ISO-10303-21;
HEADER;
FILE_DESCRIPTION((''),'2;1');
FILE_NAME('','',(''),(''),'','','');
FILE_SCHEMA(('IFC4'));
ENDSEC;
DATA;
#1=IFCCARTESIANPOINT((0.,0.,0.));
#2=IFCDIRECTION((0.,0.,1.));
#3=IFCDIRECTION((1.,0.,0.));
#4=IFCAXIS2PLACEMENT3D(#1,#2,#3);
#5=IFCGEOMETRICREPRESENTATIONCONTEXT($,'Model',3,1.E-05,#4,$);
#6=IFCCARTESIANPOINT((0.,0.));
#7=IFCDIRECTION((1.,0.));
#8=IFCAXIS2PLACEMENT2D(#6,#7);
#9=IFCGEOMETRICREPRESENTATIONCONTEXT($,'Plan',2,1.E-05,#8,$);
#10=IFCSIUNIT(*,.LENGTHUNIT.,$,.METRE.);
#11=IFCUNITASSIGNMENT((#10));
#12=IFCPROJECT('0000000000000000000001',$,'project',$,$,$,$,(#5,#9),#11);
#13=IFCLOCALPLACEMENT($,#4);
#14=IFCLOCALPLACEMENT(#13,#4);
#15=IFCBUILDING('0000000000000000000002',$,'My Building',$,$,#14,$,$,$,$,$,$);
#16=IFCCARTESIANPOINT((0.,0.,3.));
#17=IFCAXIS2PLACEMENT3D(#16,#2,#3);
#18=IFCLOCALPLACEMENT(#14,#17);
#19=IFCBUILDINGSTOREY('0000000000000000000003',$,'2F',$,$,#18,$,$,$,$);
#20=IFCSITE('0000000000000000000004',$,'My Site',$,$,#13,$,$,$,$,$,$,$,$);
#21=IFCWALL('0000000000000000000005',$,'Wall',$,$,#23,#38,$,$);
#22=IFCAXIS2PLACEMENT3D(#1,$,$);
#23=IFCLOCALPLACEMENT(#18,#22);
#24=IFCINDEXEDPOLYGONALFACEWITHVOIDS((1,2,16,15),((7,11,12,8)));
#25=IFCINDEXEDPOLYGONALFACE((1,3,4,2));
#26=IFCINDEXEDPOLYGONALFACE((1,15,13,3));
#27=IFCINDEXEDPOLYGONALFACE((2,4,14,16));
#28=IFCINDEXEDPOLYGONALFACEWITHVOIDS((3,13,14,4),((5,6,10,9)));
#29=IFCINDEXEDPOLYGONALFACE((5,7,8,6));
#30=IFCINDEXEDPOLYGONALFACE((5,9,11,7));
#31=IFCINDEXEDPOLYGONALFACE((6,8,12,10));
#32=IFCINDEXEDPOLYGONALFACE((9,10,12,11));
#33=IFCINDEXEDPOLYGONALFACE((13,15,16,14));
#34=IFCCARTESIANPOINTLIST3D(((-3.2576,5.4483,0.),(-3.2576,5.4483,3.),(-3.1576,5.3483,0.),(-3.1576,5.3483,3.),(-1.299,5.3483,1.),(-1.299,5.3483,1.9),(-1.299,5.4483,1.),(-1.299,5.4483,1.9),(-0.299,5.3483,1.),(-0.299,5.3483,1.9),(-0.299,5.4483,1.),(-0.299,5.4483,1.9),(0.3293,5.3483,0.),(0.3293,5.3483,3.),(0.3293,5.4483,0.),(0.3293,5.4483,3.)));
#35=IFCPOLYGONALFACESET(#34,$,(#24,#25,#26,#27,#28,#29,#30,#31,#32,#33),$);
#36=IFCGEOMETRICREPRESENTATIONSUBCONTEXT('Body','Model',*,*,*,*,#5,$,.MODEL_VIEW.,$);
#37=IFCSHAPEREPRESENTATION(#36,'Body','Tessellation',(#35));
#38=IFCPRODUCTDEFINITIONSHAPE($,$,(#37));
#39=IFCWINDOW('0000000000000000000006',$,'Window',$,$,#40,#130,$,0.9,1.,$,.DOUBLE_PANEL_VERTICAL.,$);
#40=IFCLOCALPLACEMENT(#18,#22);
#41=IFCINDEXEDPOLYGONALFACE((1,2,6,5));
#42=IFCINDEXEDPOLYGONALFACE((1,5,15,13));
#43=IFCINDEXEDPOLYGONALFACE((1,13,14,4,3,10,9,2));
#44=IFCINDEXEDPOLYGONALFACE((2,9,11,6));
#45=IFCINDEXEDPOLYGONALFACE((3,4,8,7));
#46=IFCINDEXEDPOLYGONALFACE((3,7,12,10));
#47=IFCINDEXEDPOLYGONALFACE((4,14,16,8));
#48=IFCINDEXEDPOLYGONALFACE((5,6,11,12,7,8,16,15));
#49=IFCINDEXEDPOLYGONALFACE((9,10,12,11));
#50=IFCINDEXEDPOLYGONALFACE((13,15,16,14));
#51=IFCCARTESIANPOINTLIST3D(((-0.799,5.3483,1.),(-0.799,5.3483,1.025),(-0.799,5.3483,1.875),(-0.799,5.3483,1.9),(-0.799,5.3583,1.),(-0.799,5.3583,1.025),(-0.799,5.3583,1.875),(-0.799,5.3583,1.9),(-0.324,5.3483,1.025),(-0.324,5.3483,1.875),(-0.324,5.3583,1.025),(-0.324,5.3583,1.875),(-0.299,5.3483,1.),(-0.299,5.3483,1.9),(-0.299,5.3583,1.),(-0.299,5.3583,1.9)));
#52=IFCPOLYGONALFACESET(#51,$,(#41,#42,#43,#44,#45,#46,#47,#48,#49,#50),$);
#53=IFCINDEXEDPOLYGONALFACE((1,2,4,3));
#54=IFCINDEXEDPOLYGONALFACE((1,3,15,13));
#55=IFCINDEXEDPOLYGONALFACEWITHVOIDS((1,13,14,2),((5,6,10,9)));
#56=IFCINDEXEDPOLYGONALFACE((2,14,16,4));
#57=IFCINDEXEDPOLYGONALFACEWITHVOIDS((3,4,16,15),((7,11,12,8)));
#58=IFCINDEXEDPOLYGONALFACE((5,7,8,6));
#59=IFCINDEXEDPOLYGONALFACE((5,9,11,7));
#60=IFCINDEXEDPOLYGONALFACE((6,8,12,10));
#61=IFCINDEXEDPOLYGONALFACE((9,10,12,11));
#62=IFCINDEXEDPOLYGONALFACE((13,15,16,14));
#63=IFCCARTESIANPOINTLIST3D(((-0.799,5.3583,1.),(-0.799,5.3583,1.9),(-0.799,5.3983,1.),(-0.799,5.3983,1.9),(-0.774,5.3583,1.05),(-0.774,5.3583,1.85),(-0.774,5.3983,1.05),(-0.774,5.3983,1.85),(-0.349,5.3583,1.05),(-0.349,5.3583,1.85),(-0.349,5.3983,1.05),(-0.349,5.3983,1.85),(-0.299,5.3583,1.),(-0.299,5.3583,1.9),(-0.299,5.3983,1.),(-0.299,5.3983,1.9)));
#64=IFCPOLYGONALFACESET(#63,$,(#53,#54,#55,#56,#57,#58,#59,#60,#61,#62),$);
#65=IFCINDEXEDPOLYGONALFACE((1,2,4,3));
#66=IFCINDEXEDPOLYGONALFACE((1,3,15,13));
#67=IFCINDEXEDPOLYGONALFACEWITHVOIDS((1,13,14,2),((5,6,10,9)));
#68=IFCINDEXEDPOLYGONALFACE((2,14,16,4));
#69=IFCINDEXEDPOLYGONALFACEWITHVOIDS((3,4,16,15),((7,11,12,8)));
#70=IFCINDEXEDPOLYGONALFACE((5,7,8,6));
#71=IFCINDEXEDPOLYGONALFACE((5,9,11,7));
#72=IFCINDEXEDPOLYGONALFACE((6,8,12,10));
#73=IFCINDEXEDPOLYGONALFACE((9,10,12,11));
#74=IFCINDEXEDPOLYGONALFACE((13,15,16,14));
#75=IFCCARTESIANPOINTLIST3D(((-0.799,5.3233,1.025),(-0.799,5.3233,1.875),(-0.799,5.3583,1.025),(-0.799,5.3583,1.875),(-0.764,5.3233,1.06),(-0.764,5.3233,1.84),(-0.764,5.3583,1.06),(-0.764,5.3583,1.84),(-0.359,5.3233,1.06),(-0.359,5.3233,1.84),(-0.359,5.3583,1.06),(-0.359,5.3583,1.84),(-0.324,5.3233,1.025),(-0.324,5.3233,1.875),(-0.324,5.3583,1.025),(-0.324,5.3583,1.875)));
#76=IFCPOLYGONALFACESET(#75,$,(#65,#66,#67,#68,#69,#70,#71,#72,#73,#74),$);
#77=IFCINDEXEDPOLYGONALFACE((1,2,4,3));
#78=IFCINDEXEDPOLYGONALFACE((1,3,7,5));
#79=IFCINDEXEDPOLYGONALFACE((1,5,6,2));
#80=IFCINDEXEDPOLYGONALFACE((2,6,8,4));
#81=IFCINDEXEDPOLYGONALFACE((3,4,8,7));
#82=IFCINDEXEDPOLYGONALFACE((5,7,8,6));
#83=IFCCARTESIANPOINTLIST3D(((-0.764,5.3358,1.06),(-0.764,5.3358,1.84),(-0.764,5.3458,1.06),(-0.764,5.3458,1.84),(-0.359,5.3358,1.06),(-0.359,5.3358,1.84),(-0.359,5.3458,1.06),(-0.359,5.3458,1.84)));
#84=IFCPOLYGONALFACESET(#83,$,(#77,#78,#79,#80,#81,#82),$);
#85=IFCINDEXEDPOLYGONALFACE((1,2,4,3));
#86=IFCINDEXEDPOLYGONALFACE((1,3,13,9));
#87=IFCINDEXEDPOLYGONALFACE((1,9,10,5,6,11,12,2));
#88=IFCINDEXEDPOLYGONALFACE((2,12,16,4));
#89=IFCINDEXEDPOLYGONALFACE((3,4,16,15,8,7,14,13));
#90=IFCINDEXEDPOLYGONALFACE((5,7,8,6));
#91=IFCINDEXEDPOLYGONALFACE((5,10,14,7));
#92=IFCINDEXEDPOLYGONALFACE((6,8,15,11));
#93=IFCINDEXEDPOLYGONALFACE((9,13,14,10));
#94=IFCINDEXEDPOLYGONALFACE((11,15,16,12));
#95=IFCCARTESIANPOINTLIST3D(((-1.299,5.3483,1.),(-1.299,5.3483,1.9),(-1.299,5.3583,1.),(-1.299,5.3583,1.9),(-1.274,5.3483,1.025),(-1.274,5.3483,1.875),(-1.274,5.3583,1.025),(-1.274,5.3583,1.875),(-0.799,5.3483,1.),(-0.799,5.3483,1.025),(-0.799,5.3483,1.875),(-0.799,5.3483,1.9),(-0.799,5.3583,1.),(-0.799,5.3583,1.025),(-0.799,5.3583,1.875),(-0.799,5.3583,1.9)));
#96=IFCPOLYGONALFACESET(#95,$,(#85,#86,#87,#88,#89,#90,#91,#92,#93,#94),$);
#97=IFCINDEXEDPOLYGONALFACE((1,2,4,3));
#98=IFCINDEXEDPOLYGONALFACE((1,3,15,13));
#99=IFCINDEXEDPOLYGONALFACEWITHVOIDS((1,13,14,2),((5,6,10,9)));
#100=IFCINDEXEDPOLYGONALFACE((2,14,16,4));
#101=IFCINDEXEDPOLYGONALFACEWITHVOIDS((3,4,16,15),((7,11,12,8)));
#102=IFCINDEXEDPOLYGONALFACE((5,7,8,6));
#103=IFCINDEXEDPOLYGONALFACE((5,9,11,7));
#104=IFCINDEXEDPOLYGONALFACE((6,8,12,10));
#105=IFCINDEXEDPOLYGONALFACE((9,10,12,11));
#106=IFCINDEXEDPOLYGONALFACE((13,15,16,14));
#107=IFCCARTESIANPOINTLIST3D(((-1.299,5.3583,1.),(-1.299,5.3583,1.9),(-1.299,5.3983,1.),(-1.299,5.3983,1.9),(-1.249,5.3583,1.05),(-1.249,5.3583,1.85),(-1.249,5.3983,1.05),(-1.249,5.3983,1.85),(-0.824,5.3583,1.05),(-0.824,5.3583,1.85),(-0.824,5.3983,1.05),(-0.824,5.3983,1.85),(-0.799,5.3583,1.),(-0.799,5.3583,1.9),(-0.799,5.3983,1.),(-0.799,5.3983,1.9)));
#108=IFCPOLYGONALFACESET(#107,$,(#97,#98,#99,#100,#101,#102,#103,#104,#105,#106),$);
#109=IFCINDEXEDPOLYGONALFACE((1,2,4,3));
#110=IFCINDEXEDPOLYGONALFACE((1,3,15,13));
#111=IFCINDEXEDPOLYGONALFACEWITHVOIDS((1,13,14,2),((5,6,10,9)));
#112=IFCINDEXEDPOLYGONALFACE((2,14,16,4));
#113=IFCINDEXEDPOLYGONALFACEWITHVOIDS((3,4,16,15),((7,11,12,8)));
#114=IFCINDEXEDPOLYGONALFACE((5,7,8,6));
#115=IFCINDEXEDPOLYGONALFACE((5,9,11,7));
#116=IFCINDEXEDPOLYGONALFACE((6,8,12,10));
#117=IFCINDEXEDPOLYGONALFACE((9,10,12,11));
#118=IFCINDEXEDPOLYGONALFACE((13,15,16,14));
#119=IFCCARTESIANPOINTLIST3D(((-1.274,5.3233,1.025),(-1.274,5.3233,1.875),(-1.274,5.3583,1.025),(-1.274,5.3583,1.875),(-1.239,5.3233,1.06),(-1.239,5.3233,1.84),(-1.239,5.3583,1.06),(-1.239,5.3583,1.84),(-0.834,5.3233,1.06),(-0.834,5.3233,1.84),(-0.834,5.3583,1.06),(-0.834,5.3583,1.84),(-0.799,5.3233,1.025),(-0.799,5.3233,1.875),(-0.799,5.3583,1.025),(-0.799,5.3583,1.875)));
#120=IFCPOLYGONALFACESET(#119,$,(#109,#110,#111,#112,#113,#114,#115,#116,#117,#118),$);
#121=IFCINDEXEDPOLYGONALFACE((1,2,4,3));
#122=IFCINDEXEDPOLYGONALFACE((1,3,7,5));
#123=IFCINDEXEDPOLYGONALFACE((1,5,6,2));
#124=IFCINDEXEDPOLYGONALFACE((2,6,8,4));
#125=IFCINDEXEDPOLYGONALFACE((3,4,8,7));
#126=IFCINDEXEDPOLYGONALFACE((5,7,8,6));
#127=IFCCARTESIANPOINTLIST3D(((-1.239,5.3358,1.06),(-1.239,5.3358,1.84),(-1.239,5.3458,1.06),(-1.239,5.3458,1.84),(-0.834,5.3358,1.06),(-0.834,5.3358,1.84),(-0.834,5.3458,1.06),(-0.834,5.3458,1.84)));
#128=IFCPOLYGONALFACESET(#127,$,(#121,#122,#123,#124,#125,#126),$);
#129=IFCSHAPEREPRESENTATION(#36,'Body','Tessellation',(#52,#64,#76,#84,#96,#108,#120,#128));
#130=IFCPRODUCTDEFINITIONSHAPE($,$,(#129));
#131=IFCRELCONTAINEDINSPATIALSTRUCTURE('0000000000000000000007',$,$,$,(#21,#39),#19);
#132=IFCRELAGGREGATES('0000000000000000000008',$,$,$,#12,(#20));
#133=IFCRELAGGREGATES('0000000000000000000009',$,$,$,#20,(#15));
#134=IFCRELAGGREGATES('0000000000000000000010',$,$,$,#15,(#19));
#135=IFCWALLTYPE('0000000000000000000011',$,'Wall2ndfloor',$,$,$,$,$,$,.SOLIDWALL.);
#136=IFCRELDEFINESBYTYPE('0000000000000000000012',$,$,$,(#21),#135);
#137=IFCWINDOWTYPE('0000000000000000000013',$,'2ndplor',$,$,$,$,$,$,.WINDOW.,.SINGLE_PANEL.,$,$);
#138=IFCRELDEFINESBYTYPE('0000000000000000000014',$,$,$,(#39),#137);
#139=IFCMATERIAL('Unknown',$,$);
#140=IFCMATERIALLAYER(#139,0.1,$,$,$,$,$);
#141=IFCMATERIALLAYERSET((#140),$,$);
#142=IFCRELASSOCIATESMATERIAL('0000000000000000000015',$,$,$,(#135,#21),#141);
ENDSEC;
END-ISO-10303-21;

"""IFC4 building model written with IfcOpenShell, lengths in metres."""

from ifc_helpers import new_model, entity, si_unit, frame, origin_with_axes, origin_2d_with_axis, place, context, subcontext, project, spatial, line, indexed_curve, outline, extrude, shape, source, transform, mapped, material, layer, layer_set, layer_usage, type_object, type_shapes, element, fill, save


model = new_model("IFC4")

# Units and contexts
model_context = context("Model", 3, precision=1e-05, world=origin_with_axes())
plan_context = context("Plan", 2, precision=1e-05, world=origin_2d_with_axis())
body_context_1 = subcontext(model_context, "Body", "Model", "MODEL_VIEW")
body_context_2 = subcontext(plan_context, "Body", "Plan", "PLAN_VIEW")
ifc_project = project(units=[si_unit("LENGTHUNIT", "METRE")], contexts=[model_context, plan_context])

# Site, building, storey
site_placement = place(None, origin_with_axes())
site = spatial("IfcSite", under=ifc_project, at=site_placement, Name="My Site")
building_placement = place(site_placement, origin_with_axes())
building = spatial("IfcBuilding", under=site, at=building_placement, Name="My Building")
storey_placement = place(building_placement, frame((0.0, 0.0, 3.0), z_axis=(0.0, 0.0, 1.0), x_axis=(1.0, 0.0, 0.0)))
storey = spatial("IfcBuildingStorey", under=building, at=storey_placement, Name="2F")

# Shared definitions
ifc_material = material(Name="Unknown")

# Shared definitions
ifc_layer_1 = layer(ifc_material, 0.1)
ifc_layer_set_1 = layer_set([ifc_layer_1])
wall_type = type_object("IfcWallType", Name="Wall2ndfloor", PredefinedType="SOLIDWALL", material=ifc_layer_set_1)

# Wall, opening, window
ifc_layer_usage_1 = layer_usage(ifc_layer_set_1, "AXIS2", "POSITIVE", 0.0)
wall_1_placement = place(storey_placement, frame((0.4293, 5.4483, 0.0), z_axis=(0.0, 0.0, 1.0), x_axis=(-1.0, 0.0, 0.0)))
wall_1 = element("IfcWall", 1, at=wall_1_placement, inside=storey, type_object=wall_type, material=ifc_layer_usage_1, Name="Wall", context=body_context_1, shape_type="SweptSolid", body=[
    extrude(outline(indexed_curve([(0.1, 0.0), (0.1, 0.1), (3.5869, 0.1), (3.6869, 0.0)], segments=[line(1, 2, 3, 4, 1)])), origin_with_axes(), (0.0, 0.0, 1.0), 3.0),
])
shared_shape_1 = source(origin_with_axes(), body_context_1, "Body", "SweptSolid", [
    extrude(outline(indexed_curve([(0.0, 0.0), (1.0, 0.0), (1.0, 0.9), (0.0, 0.9)], segments=[line(1, 2, 3, 4, 1)])), frame((0.0, -0.6, 0.0), z_axis=(0.0, -1.0, 0.0), x_axis=(1.0, 0.0, 0.0)), (0.0, 0.0, -1.0), 1.2),
])
opening_1_placement = place(wall_1_placement, frame((0.7283, 0.0, 1.0), z_axis=(0.0, 0.0, 1.0), x_axis=(1.0, 0.0, 0.0)))
opening_1 = element("IfcOpeningElement", 2, at=opening_1_placement, cuts=wall_1, PredefinedType="OPENING", context=body_context_1, shape_type="MappedRepresentation", body=[
    mapped(shared_shape_1, transform((0.0, 0.0, 0.0), x_axis=(1.0, 0.0, 0.0), y_axis=(0.0, 1.0, 0.0), z_axis=(0.0, 0.0, 1.0), scale=1.0)),
])
window_type_1 = type_object("IfcWindowType", Name="2ndplor", PartitioningType="SINGLE_PANEL", PredefinedType="WINDOW")
shared_shape_2 = source(origin_with_axes(), body_context_1, "Body", "SweptSolid", [
    extrude(outline(indexed_curve([(0.5, 0.0), (0.0, 0.0), (0.0, 0.9), (0.5, 0.9), (0.5, 0.875), (0.025, 0.875), (0.025, 0.025), (0.5, 0.025)], segments=[line(1, 2, 3, 4, 5, 6, 7, 8, 1)])), frame((0.0, 0.09, 0.0), z_axis=(0.0, -1.0, 0.0), x_axis=(1.0, 0.0, 0.0)), (0.0, 0.0, -1.0), 0.01),
    extrude(outline(indexed_curve([(0.0, 0.0), (0.5, 0.0), (0.5, 0.9), (0.0, 0.9)], segments=[line(1, 2, 3, 4, 1)]), holes=[indexed_curve([(0.05, 0.05), (0.475, 0.05), (0.475, 0.85), (0.05, 0.85)], segments=[line(1, 2, 3, 4, 1)])]), frame((0.0, 0.05, 0.0), z_axis=(0.0, -1.0, 0.0), x_axis=(1.0, 0.0, 0.0)), (0.0, 0.0, -1.0), 0.04),
    extrude(outline(indexed_curve([(0.0, 0.0), (0.475, 0.0), (0.475, 0.85), (0.0, 0.85)], segments=[line(1, 2, 3, 4, 1)]), holes=[indexed_curve([(0.035, 0.035), (0.44, 0.035), (0.44, 0.815), (0.035, 0.815)], segments=[line(1, 2, 3, 4, 1)])]), frame((0.025, 0.09, 0.025), z_axis=(0.0, -1.0, 0.0), x_axis=(1.0, 0.0, 0.0)), (0.0, 0.0, -1.0), 0.035),
    extrude(outline(indexed_curve([(0.035, 0.035), (0.44, 0.035), (0.44, 0.815), (0.035, 0.815)], segments=[line(1, 2, 3, 4, 1)])), frame((0.025, 0.1025, 0.025), z_axis=(0.0, -1.0, 0.0), x_axis=(1.0, 0.0, 0.0)), (0.0, 0.0, -1.0), 0.01),
    extrude(outline(indexed_curve([(0.0, 0.9), (0.5, 0.9), (0.5, 0.0), (0.0, 0.0), (0.0, 0.025), (0.475, 0.025), (0.475, 0.875), (0.0, 0.875)], segments=[line(1, 2, 3, 4, 5, 6, 7, 8, 1)])), frame((0.5, 0.09, 0.0), z_axis=(0.0, -1.0, 0.0), x_axis=(1.0, 0.0, 0.0)), (0.0, 0.0, -1.0), 0.01),
    extrude(outline(indexed_curve([(0.0, 0.0), (0.5, 0.0), (0.5, 0.9), (0.0, 0.9)], segments=[line(1, 2, 3, 4, 1)]), holes=[indexed_curve([(0.025, 0.05), (0.45, 0.05), (0.45, 0.85), (0.025, 0.85)], segments=[line(1, 2, 3, 4, 1)])]), frame((0.5, 0.05, 0.0), z_axis=(0.0, -1.0, 0.0), x_axis=(1.0, 0.0, 0.0)), (0.0, 0.0, -1.0), 0.04),
    extrude(outline(indexed_curve([(0.0, 0.0), (0.475, 0.0), (0.475, 0.85), (0.0, 0.85)], segments=[line(1, 2, 3, 4, 1)]), holes=[indexed_curve([(0.035, 0.035), (0.44, 0.035), (0.44, 0.815), (0.035, 0.815)], segments=[line(1, 2, 3, 4, 1)])]), frame((0.5, 0.09, 0.025), z_axis=(0.0, -1.0, 0.0), x_axis=(1.0, 0.0, 0.0)), (0.0, 0.0, -1.0), 0.035),
    extrude(outline(indexed_curve([(0.035, 0.035), (0.44, 0.035), (0.44, 0.815), (0.035, 0.815)], segments=[line(1, 2, 3, 4, 1)])), frame((0.5, 0.1025, 0.025), z_axis=(0.0, -1.0, 0.0), x_axis=(1.0, 0.0, 0.0)), (0.0, 0.0, -1.0), 0.01),
])
shared_shape_3 = source(origin_with_axes(), body_context_2, "Body", "Curve2D", [
    entity("IfcIndexedPolyCurve", entity("IfcCartesianPointList2D", [[0.05, 0.05], [0.475, 0.05]])),
    entity("IfcIndexedPolyCurve", entity("IfcCartesianPointList2D", [[0.0, 0.1], [0.025, 0.1], [0.025, 0.09], [0.05, 0.09], [0.05, 0.05], [0.0, 0.05]]), [entity("IfcLineIndex", [1, 2, 3, 4, 5, 6, 1])]),
    entity("IfcIndexedPolyCurve", entity("IfcCartesianPointList2D", [[0.5, 0.1], [0.5, 0.1], [0.5, 0.09], [0.475, 0.09], [0.475, 0.05], [0.5, 0.05]])),
    entity("IfcIndexedPolyCurve", entity("IfcCartesianPointList2D", [[0.025, 0.09], [0.06, 0.09], [0.06, 0.125], [0.025, 0.125]]), [entity("IfcLineIndex", [1, 2, 3, 4, 1])]),
    entity("IfcIndexedPolyCurve", entity("IfcCartesianPointList2D", [[0.5, 0.09], [0.465, 0.09], [0.465, 0.125], [0.5, 0.125]]), [entity("IfcLineIndex", [1, 2, 3, 4, 1])]),
    entity("IfcIndexedPolyCurve", entity("IfcCartesianPointList2D", [[0.06, 0.09], [0.465, 0.09]])),
    entity("IfcIndexedPolyCurve", entity("IfcCartesianPointList2D", [[0.06, 0.125], [0.465, 0.125]])),
    entity("IfcIndexedPolyCurve", entity("IfcCartesianPointList2D", [[0.06, 0.1075], [0.465, 0.1075]])),
    entity("IfcIndexedPolyCurve", entity("IfcCartesianPointList2D", [[0.525, 0.05], [0.95, 0.05]])),
    entity("IfcIndexedPolyCurve", entity("IfcCartesianPointList2D", [[0.5, 0.1], [0.5, 0.1], [0.5, 0.09], [0.525, 0.09], [0.525, 0.05], [0.5, 0.05]])),
    entity("IfcIndexedPolyCurve", entity("IfcCartesianPointList2D", [[1.0, 0.1], [0.975, 0.1], [0.975, 0.09], [0.95, 0.09], [0.95, 0.05], [1.0, 0.05]]), [entity("IfcLineIndex", [1, 2, 3, 4, 5, 6, 1])]),
    entity("IfcIndexedPolyCurve", entity("IfcCartesianPointList2D", [[0.5, 0.09], [0.535, 0.09], [0.535, 0.125], [0.5, 0.125]]), [entity("IfcLineIndex", [1, 2, 3, 4, 1])]),
    entity("IfcIndexedPolyCurve", entity("IfcCartesianPointList2D", [[0.975, 0.09], [0.94, 0.09], [0.94, 0.125], [0.975, 0.125]]), [entity("IfcLineIndex", [1, 2, 3, 4, 1])]),
    entity("IfcIndexedPolyCurve", entity("IfcCartesianPointList2D", [[0.535, 0.09], [0.94, 0.09]])),
    entity("IfcIndexedPolyCurve", entity("IfcCartesianPointList2D", [[0.535, 0.125], [0.94, 0.125]])),
    entity("IfcIndexedPolyCurve", entity("IfcCartesianPointList2D", [[0.535, 0.1075], [0.94, 0.1075]])),
])
type_shapes(window_type_1, [shared_shape_2, shared_shape_3])
window_1_placement = place(opening_1_placement, origin_with_axes())
window_1 = element("IfcWindow", 3, at=window_1_placement, inside=storey, type_object=window_type_1, Name="Window", OverallHeight=0.9, OverallWidth=1.0, PartitioningType="DOUBLE_PANEL_VERTICAL", shapes=[
    shape(body_context_1, "Body", "MappedRepresentation", [mapped(shared_shape_2, transform((0.0, 0.0, 0.0), x_axis=(1.0, 0.0, 0.0), y_axis=(0.0, 1.0, 0.0), z_axis=(0.0, 0.0, 1.0), scale=1.0))]),
    shape(body_context_2, "Body", "MappedRepresentation", [mapped(shared_shape_3, transform((0.0, 0.0, 0.0), x_axis=(1.0, 0.0, 0.0), y_axis=(0.0, 1.0, 0.0), z_axis=(0.0, 0.0, 1.0), scale=1.0))]),
])
fill(opening_1, window_1)

save(model, "model.ifc")
